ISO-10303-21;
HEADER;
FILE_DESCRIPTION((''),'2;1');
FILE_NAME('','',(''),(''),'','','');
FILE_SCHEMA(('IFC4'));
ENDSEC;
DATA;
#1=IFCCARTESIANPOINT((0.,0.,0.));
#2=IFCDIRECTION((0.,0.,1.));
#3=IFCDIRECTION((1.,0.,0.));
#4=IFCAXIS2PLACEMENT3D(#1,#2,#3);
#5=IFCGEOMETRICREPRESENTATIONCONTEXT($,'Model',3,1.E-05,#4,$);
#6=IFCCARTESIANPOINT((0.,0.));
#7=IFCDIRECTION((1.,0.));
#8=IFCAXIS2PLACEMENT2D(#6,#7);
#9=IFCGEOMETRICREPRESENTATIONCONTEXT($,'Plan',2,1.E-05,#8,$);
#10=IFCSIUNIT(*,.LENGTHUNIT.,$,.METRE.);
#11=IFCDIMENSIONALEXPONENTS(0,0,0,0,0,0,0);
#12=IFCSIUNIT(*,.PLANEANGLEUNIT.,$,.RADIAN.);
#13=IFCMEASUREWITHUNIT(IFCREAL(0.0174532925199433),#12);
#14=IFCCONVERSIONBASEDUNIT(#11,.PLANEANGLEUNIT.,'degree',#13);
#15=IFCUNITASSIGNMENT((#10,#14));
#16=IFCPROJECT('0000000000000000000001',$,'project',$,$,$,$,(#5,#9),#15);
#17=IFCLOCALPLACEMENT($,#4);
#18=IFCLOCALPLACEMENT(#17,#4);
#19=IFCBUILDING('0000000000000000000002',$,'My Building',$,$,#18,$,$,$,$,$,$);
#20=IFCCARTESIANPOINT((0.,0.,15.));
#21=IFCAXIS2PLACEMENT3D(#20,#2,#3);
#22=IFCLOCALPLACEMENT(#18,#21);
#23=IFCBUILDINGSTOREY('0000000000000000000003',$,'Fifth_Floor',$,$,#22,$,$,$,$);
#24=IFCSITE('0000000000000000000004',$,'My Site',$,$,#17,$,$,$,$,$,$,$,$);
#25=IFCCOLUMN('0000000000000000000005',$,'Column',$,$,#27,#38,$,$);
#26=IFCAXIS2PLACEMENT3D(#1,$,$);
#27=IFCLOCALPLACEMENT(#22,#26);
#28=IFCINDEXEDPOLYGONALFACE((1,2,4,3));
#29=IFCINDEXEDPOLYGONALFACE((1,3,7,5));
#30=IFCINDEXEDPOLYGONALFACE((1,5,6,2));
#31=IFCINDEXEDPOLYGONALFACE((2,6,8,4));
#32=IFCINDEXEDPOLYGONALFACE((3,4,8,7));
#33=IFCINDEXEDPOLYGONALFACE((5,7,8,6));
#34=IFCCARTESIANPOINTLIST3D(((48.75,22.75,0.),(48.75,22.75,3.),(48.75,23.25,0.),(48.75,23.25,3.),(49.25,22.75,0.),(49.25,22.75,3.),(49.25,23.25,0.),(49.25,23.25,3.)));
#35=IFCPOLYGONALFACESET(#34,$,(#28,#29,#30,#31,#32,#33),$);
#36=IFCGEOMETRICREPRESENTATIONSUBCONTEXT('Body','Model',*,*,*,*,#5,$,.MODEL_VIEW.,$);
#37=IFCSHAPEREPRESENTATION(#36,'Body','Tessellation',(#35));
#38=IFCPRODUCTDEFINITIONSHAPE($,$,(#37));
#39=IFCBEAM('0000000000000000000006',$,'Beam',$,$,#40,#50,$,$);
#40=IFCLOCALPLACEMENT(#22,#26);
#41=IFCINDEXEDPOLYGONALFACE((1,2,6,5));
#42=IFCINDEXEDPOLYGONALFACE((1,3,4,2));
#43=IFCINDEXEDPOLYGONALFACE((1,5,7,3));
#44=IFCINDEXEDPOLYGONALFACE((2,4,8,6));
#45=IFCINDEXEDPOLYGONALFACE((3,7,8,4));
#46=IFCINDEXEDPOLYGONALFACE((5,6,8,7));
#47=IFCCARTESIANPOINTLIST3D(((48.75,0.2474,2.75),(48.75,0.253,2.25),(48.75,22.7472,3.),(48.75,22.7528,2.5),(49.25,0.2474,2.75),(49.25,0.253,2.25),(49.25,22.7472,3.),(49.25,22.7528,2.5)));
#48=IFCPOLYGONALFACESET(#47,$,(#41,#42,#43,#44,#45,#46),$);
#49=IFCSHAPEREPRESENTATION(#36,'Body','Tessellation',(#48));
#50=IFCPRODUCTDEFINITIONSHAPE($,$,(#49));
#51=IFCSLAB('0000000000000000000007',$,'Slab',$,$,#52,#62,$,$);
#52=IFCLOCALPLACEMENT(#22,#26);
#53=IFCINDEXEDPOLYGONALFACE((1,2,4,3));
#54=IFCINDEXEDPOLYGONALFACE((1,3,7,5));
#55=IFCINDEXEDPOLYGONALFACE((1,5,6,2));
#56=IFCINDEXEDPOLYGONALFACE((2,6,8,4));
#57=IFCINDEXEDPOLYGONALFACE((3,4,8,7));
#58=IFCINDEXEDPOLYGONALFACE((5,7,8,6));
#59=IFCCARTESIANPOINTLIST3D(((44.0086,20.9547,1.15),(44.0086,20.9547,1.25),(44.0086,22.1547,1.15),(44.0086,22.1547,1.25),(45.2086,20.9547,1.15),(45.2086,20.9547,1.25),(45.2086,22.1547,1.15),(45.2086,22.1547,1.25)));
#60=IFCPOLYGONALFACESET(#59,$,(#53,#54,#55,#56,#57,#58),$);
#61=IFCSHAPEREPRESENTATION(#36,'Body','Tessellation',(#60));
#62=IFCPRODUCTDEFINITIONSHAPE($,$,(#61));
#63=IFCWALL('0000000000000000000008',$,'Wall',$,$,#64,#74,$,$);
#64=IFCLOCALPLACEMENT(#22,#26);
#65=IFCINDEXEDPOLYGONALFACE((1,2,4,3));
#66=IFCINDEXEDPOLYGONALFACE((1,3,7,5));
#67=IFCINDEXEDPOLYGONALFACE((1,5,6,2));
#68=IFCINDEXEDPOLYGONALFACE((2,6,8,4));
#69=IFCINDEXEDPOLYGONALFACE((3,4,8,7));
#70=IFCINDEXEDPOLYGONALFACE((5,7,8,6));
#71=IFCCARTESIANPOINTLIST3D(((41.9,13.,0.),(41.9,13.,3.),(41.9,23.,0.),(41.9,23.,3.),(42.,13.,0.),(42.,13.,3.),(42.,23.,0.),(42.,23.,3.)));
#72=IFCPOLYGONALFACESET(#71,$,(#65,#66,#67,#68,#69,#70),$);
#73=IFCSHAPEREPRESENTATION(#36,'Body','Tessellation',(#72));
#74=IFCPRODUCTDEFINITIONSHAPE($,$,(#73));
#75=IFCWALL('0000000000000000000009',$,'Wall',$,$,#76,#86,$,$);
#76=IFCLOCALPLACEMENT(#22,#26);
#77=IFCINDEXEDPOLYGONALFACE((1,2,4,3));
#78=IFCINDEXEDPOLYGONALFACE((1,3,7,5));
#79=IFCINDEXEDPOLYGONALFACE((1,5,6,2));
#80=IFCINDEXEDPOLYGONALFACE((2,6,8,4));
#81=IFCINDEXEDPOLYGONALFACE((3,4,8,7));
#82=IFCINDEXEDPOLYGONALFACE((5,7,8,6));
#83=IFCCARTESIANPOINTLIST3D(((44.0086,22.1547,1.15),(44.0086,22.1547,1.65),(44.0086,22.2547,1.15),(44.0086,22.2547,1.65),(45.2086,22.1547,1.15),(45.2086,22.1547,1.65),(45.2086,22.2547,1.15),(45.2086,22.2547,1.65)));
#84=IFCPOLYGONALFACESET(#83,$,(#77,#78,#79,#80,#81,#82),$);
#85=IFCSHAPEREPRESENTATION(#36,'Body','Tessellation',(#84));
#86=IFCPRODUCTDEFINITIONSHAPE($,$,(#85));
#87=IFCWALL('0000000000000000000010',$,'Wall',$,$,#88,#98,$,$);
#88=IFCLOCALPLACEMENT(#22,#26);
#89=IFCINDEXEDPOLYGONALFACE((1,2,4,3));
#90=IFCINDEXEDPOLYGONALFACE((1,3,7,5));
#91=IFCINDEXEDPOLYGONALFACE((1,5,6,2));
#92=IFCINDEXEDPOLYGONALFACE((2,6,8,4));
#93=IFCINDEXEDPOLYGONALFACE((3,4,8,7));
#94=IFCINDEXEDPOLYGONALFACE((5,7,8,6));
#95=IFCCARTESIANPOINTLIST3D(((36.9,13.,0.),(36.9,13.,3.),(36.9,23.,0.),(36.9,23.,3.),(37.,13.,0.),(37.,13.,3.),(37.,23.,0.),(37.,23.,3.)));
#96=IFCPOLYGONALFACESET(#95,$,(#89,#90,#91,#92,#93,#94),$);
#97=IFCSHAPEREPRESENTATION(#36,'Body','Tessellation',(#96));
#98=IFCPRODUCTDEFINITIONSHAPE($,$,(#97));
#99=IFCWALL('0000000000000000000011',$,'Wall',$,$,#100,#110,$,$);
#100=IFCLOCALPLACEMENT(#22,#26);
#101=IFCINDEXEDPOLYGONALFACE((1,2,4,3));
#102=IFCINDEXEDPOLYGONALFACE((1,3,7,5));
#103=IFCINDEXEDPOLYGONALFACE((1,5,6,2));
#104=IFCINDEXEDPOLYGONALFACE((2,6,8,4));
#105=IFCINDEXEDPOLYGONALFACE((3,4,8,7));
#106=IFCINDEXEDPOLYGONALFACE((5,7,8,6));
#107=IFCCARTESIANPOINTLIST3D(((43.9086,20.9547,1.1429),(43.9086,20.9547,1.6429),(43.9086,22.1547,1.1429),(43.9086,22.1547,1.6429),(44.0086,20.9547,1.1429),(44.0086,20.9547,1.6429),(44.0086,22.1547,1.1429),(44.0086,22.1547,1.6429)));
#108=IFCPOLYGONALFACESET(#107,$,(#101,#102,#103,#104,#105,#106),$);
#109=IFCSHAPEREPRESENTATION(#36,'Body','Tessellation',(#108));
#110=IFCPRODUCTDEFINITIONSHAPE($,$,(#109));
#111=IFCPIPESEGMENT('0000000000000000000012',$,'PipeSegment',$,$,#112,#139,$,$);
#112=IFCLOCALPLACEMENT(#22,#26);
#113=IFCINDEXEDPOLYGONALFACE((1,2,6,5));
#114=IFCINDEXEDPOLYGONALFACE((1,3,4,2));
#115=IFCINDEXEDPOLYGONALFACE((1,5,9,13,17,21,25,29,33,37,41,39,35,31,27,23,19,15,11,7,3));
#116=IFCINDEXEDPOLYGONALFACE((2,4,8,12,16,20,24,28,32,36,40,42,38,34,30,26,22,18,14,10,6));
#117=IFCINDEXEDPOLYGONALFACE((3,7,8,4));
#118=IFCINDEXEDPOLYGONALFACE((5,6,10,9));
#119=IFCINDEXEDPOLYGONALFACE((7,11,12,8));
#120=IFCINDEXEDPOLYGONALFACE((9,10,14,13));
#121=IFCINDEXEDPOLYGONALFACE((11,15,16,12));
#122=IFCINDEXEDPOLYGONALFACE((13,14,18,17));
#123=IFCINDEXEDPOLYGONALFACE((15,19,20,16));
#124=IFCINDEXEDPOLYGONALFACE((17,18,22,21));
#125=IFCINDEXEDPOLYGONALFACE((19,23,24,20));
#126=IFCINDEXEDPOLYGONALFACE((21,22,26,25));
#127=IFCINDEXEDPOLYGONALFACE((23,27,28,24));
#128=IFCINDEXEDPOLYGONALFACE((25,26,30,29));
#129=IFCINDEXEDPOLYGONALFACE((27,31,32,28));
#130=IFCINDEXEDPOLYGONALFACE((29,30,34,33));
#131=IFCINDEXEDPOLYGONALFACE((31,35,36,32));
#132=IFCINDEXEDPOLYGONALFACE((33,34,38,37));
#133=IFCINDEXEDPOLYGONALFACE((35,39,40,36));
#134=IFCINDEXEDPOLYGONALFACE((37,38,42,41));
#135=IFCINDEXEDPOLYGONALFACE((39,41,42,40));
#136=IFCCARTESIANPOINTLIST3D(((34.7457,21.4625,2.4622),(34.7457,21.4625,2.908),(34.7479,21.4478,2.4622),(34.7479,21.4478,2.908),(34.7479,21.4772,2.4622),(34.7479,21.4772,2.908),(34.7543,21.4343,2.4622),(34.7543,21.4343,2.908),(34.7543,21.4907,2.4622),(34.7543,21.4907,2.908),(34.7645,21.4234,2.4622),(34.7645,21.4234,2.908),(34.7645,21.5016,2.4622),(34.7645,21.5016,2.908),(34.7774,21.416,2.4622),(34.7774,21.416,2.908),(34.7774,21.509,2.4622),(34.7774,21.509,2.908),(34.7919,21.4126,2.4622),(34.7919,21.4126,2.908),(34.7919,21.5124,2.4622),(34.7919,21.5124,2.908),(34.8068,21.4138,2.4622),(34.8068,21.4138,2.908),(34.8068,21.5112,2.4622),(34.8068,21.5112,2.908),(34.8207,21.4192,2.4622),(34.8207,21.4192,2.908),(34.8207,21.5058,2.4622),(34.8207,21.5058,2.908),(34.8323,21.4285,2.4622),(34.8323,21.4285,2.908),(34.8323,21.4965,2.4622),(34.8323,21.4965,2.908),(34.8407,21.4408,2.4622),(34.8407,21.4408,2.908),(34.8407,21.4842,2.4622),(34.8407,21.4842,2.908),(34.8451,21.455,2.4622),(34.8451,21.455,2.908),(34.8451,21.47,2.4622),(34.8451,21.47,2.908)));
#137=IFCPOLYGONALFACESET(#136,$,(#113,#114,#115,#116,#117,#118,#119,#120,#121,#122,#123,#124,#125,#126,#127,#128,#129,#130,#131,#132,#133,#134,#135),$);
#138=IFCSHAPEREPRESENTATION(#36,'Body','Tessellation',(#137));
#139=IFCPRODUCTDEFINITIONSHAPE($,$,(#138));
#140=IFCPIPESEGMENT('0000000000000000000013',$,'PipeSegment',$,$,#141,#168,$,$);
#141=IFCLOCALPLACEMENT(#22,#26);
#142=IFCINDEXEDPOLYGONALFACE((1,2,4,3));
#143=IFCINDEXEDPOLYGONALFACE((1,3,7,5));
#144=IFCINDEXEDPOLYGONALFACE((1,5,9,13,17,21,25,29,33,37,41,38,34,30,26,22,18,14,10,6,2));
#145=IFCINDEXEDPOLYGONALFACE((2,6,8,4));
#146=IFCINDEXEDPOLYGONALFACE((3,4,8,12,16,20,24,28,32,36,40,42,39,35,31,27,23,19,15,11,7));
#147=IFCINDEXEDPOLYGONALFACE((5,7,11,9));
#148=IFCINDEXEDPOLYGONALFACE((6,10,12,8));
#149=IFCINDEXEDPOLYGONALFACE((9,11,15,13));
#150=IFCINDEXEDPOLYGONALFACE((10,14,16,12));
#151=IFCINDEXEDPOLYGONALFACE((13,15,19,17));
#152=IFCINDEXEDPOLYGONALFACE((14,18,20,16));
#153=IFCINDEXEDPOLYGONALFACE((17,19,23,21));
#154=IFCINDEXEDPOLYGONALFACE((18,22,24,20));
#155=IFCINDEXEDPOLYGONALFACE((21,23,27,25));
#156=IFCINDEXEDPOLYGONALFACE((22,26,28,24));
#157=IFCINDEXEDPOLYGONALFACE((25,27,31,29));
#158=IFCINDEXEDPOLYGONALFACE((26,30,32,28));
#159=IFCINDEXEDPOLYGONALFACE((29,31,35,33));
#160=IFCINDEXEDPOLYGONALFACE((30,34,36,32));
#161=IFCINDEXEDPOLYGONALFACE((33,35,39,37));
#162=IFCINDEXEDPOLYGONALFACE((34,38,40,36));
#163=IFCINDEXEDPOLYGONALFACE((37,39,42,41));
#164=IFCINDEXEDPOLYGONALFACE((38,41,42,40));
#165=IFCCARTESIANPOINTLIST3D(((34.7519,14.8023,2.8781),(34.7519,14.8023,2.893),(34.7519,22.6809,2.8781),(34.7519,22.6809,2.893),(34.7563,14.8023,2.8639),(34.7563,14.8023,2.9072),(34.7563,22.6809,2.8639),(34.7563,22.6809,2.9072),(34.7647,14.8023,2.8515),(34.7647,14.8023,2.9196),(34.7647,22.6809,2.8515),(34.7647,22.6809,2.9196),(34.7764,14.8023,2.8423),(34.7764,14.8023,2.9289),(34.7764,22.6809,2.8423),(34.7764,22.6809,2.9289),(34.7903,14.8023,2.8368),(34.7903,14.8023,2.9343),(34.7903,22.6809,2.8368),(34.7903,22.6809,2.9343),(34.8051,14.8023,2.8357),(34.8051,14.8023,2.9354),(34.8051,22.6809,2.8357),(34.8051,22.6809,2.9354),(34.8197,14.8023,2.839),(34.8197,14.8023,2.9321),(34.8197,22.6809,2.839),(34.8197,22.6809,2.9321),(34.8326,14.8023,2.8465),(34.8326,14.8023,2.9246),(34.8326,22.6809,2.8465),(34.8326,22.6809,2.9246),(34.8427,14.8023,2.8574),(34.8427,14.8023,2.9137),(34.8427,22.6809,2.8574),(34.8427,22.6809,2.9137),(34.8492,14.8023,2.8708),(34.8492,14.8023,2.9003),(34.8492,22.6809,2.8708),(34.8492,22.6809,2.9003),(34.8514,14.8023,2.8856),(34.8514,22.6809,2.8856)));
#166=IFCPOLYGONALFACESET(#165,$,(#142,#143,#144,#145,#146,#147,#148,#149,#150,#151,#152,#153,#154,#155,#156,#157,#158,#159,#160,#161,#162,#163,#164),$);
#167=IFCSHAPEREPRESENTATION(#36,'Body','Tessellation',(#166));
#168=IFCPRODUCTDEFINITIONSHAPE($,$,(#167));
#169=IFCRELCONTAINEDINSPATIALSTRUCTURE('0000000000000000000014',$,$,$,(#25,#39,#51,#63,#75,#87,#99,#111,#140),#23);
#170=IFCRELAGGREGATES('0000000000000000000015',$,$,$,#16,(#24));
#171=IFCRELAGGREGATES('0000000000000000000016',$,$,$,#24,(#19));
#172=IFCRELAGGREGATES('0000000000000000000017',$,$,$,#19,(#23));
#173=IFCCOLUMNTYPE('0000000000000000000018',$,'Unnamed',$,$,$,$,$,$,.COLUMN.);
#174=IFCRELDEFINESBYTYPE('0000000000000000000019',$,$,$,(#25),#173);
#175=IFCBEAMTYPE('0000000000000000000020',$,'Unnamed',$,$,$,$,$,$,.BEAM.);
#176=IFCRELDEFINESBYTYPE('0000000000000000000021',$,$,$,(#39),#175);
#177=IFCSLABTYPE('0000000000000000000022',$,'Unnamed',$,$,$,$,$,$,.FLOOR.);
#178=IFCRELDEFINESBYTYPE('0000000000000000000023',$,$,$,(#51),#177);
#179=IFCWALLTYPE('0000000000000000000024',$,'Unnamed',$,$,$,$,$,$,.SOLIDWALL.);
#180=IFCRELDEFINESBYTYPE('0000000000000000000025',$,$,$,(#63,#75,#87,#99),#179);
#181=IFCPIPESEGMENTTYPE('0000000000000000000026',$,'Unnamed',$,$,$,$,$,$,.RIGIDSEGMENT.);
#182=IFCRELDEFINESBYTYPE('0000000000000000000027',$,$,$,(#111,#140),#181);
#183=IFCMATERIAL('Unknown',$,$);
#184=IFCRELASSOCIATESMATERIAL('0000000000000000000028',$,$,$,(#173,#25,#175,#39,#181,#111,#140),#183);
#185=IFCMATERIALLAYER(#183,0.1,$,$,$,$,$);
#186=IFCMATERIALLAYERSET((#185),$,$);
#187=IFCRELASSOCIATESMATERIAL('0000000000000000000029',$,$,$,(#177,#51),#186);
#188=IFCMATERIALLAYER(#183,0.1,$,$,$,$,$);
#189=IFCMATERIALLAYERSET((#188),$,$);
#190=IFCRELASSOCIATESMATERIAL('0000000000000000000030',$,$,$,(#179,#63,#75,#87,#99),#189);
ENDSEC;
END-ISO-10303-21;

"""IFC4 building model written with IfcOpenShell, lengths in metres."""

from ifc_helpers import new_model, entity, si_unit, converted_unit, frame, origin_with_axes, origin_2d_with_axis, place, context, subcontext, project, spatial, line, indexed_curve, rectangle, circle, outline, extrude, material, layer, layer_set, layer_usage, material_profile, profile_set, profile_usage, type_object, element, save


model = new_model("IFC4")

# Units and contexts
model_context = context("Model", 3, precision=1e-05, world=origin_with_axes())
plan_context = context("Plan", 2, precision=1e-05, world=origin_2d_with_axis())
body_context_1 = subcontext(model_context, "Body", "Model", "MODEL_VIEW")
ifc_project = project(units=[si_unit("LENGTHUNIT", "METRE"), converted_unit("PLANEANGLEUNIT", "degree", entity("IfcReal", 0.0174532925199433), si_unit("PLANEANGLEUNIT", "RADIAN"), dimensions=[0, 0, 0, 0, 0, 0, 0])], contexts=[model_context, plan_context])

# Site, building, storey
site_placement = place(None, origin_with_axes())
site = spatial("IfcSite", under=ifc_project, at=site_placement, Name="My Site")
building_placement = place(site_placement, origin_with_axes())
building = spatial("IfcBuilding", under=site, at=building_placement, Name="My Building")
storey_placement = place(building_placement, frame((0.0, 0.0, 15.0), z_axis=(0.0, 0.0, 1.0), x_axis=(1.0, 0.0, 0.0)))
storey = spatial("IfcBuildingStorey", under=building, at=storey_placement, Name="Fifth_Floor")

# Column
ifc_material = material(Name="Unknown")
ifc_material_profile_1 = material_profile(ifc_material, rectangle(XDim=0.5, YDim=0.5))
ifc_profile_set_1 = profile_set([ifc_material_profile_1])
ifc_profile_usage_1 = profile_usage(ifc_profile_set_1, cardinal=5)
column_type = type_object("IfcColumnType", Name="Unnamed", PredefinedType="COLUMN", material=ifc_profile_set_1)
column_placement = place(storey_placement, frame((49.0, 23.0, 0.0), z_axis=(0.0, 0.0, 1.0), x_axis=(1.0, 0.0, 0.0)))
element("IfcColumn", 1, at=column_placement, inside=storey, type_object=column_type, material=ifc_profile_usage_1, Name="Column", context=body_context_1, shape_type="SweptSolid", body=[
    extrude(rectangle(XDim=0.5, YDim=0.5), origin_with_axes(), (0.0, 0.0, 1.0), 3.0),
])

# Beam
ifc_material_profile_2 = material_profile(ifc_material, rectangle(XDim=0.5, YDim=0.5))
ifc_profile_set_2 = profile_set([ifc_material_profile_2])
ifc_profile_usage_2 = profile_usage(ifc_profile_set_2, cardinal=6)
beam_type = type_object("IfcBeamType", Name="Unnamed", PredefinedType="BEAM", material=ifc_profile_set_2)
beam_placement = place(storey_placement, frame((48.75, 22.75, 2.75), z_axis=(0.0, -0.999938, -0.011111), x_axis=(1.0, 0.0, 0.0)))
element("IfcBeam", 2, at=beam_placement, inside=storey, type_object=beam_type, material=ifc_profile_usage_2, Name="Beam", context=body_context_1, shape_type="SweptSolid", body=[
    extrude(rectangle(XDim=0.5, YDim=0.5), frame((0.25, 0.0, 0.0), z_axis=(0.0, 0.0, 1.0), x_axis=(1.0, 0.0, 0.0)), (0.0, 0.0, 1.0), 22.5012),
])

# Slab
ifc_layer_1 = layer(ifc_material, 0.1)
ifc_layer_set_1 = layer_set([ifc_layer_1])
ifc_layer_usage_1 = layer_usage(ifc_layer_set_1, "AXIS3", "POSITIVE", -0.1)
slab_type = type_object("IfcSlabType", Name="Unnamed", PredefinedType="FLOOR", material=ifc_layer_set_1)
slab_placement = place(storey_placement, frame((44.0086, 20.9547, 1.25), z_axis=(0.0, 0.0, 1.0), x_axis=(0.0, 1.0, 0.0)))
element("IfcSlab", 3, at=slab_placement, inside=storey, type_object=slab_type, material=ifc_layer_usage_1, Name="Slab", context=body_context_1, shape_type="SweptSolid", body=[
    extrude(outline(indexed_curve([(0.0, 0.0), (0.0, -1.2), (1.2, -1.2), (1.2, 0.0), (0.0, 0.0)])), frame((0.0, 0.0, -0.1), z_axis=(0.0, 0.0, 1.0), x_axis=(1.0, 0.0, 0.0)), (0.0, 0.0, 1.0), 0.1),
])

# Walls
ifc_layer_2 = layer(ifc_material, 0.1)
ifc_layer_set_2 = layer_set([ifc_layer_2])
ifc_layer_usage_2 = layer_usage(ifc_layer_set_2, "AXIS2", "POSITIVE", 0.0)
wall_type = type_object("IfcWallType", Name="Unnamed", PredefinedType="SOLIDWALL", material=ifc_layer_set_2)
wall_1_placement = place(storey_placement, frame((41.9, 23.0, 0.0), z_axis=(0.0, 0.0, 1.0), x_axis=(0.0, -1.0, 0.0)))
element("IfcWall", 4, at=wall_1_placement, inside=storey, type_object=wall_type, material=ifc_layer_usage_2, Name="Wall", context=body_context_1, shape_type="SweptSolid", body=[
    extrude(outline(indexed_curve([(0.0, 0.0), (0.0, 0.1), (10.0, 0.1), (10.0, 0.0)], segments=[line(1, 2, 3, 4, 1)])), origin_with_axes(), (0.0, 0.0, 1.0), 3.0),
])
ifc_layer_usage_3 = layer_usage(ifc_layer_set_2, "AXIS2", "POSITIVE", 0.0)
wall_2_placement = place(storey_placement, frame((45.2086, 22.2547, 1.15), z_axis=(0.0, 0.0, 1.0), x_axis=(-1.0, 0.0, 0.0)))
element("IfcWall", 5, at=wall_2_placement, inside=storey, type_object=wall_type, material=ifc_layer_usage_3, Name="Wall", context=body_context_1, shape_type="SweptSolid", body=[
    extrude(outline(indexed_curve([(0.0, 0.0), (0.0, 0.1), (1.2, 0.1), (1.2, 0.0)], segments=[line(1, 2, 3, 4, 1)])), origin_with_axes(), (0.0, 0.0, 1.0), 0.5),
])
ifc_layer_usage_4 = layer_usage(ifc_layer_set_2, "AXIS2", "POSITIVE", 0.0)
wall_3_placement = place(storey_placement, frame((36.9, 23.0, 0.0), z_axis=(0.0, 0.0, 1.0), x_axis=(0.0, -1.0, 0.0)))
element("IfcWall", 6, at=wall_3_placement, inside=storey, type_object=wall_type, material=ifc_layer_usage_4, Name="Wall", context=body_context_1, shape_type="SweptSolid", body=[
    extrude(outline(indexed_curve([(0.0, 0.0), (0.0, 0.1), (10.0, 0.1), (10.0, 0.0)], segments=[line(1, 2, 3, 4, 1)])), origin_with_axes(), (0.0, 0.0, 1.0), 3.0),
])

# Wall
ifc_layer_usage_5 = layer_usage(ifc_layer_set_2, "AXIS2", "POSITIVE", 0.0)
wall_4_placement = place(storey_placement, frame((44.0086, 20.9547, 1.1429), z_axis=(0.0, 0.0, 1.0), x_axis=(0.0, 1.0, 0.0)))
element("IfcWall", 7, at=wall_4_placement, inside=storey, type_object=wall_type, material=ifc_layer_usage_5, Name="Wall", context=body_context_1, shape_type="SweptSolid", body=[
    extrude(outline(indexed_curve([(0.0, 0.0), (0.0, 0.1), (1.2, 0.1), (1.2, 0.0)], segments=[line(1, 2, 3, 4, 1)])), origin_with_axes(), (0.0, 0.0, 1.0), 0.5),
])

# Pipe segments
ifc_material_profile_3 = material_profile(ifc_material, circle(Radius=0.05))
ifc_profile_set_3 = profile_set([ifc_material_profile_3])
ifc_profile_usage_3 = profile_usage(ifc_profile_set_3, cardinal=5)
pipe_segment_type = type_object("IfcPipeSegmentType", Name="Unnamed", PredefinedType="RIGIDSEGMENT", material=ifc_profile_set_3)
pipe_segment_1_placement = place(storey_placement, frame((34.7957, 21.4625, 2.908), z_axis=(0.0, 0.0, -1.0), x_axis=(-1.0, 0.0, 0.0)))
element("IfcPipeSegment", 8, at=pipe_segment_1_placement, inside=storey, type_object=pipe_segment_type, material=ifc_profile_usage_3, Name="PipeSegment", context=body_context_1, shape_type="SweptSolid", body=[
    extrude(circle(Radius=0.05), origin_with_axes(), (0.0, 0.0, 1.0), 0.4458),
])
ifc_profile_usage_4 = profile_usage(ifc_profile_set_3, cardinal=5)
pipe_segment_2_placement = place(storey_placement, frame((34.8014, 22.6809, 2.8856), z_axis=(0.0, -1.0, 0.0), x_axis=(1.0, 0.0, 0.0)))
element("IfcPipeSegment", 9, at=pipe_segment_2_placement, inside=storey, type_object=pipe_segment_type, material=ifc_profile_usage_4, Name="PipeSegment", context=body_context_1, shape_type="SweptSolid", body=[
    extrude(circle(Radius=0.05), origin_with_axes(), (0.0, 0.0, 1.0), 7.8786),
])

save(model, "model.ifc")
